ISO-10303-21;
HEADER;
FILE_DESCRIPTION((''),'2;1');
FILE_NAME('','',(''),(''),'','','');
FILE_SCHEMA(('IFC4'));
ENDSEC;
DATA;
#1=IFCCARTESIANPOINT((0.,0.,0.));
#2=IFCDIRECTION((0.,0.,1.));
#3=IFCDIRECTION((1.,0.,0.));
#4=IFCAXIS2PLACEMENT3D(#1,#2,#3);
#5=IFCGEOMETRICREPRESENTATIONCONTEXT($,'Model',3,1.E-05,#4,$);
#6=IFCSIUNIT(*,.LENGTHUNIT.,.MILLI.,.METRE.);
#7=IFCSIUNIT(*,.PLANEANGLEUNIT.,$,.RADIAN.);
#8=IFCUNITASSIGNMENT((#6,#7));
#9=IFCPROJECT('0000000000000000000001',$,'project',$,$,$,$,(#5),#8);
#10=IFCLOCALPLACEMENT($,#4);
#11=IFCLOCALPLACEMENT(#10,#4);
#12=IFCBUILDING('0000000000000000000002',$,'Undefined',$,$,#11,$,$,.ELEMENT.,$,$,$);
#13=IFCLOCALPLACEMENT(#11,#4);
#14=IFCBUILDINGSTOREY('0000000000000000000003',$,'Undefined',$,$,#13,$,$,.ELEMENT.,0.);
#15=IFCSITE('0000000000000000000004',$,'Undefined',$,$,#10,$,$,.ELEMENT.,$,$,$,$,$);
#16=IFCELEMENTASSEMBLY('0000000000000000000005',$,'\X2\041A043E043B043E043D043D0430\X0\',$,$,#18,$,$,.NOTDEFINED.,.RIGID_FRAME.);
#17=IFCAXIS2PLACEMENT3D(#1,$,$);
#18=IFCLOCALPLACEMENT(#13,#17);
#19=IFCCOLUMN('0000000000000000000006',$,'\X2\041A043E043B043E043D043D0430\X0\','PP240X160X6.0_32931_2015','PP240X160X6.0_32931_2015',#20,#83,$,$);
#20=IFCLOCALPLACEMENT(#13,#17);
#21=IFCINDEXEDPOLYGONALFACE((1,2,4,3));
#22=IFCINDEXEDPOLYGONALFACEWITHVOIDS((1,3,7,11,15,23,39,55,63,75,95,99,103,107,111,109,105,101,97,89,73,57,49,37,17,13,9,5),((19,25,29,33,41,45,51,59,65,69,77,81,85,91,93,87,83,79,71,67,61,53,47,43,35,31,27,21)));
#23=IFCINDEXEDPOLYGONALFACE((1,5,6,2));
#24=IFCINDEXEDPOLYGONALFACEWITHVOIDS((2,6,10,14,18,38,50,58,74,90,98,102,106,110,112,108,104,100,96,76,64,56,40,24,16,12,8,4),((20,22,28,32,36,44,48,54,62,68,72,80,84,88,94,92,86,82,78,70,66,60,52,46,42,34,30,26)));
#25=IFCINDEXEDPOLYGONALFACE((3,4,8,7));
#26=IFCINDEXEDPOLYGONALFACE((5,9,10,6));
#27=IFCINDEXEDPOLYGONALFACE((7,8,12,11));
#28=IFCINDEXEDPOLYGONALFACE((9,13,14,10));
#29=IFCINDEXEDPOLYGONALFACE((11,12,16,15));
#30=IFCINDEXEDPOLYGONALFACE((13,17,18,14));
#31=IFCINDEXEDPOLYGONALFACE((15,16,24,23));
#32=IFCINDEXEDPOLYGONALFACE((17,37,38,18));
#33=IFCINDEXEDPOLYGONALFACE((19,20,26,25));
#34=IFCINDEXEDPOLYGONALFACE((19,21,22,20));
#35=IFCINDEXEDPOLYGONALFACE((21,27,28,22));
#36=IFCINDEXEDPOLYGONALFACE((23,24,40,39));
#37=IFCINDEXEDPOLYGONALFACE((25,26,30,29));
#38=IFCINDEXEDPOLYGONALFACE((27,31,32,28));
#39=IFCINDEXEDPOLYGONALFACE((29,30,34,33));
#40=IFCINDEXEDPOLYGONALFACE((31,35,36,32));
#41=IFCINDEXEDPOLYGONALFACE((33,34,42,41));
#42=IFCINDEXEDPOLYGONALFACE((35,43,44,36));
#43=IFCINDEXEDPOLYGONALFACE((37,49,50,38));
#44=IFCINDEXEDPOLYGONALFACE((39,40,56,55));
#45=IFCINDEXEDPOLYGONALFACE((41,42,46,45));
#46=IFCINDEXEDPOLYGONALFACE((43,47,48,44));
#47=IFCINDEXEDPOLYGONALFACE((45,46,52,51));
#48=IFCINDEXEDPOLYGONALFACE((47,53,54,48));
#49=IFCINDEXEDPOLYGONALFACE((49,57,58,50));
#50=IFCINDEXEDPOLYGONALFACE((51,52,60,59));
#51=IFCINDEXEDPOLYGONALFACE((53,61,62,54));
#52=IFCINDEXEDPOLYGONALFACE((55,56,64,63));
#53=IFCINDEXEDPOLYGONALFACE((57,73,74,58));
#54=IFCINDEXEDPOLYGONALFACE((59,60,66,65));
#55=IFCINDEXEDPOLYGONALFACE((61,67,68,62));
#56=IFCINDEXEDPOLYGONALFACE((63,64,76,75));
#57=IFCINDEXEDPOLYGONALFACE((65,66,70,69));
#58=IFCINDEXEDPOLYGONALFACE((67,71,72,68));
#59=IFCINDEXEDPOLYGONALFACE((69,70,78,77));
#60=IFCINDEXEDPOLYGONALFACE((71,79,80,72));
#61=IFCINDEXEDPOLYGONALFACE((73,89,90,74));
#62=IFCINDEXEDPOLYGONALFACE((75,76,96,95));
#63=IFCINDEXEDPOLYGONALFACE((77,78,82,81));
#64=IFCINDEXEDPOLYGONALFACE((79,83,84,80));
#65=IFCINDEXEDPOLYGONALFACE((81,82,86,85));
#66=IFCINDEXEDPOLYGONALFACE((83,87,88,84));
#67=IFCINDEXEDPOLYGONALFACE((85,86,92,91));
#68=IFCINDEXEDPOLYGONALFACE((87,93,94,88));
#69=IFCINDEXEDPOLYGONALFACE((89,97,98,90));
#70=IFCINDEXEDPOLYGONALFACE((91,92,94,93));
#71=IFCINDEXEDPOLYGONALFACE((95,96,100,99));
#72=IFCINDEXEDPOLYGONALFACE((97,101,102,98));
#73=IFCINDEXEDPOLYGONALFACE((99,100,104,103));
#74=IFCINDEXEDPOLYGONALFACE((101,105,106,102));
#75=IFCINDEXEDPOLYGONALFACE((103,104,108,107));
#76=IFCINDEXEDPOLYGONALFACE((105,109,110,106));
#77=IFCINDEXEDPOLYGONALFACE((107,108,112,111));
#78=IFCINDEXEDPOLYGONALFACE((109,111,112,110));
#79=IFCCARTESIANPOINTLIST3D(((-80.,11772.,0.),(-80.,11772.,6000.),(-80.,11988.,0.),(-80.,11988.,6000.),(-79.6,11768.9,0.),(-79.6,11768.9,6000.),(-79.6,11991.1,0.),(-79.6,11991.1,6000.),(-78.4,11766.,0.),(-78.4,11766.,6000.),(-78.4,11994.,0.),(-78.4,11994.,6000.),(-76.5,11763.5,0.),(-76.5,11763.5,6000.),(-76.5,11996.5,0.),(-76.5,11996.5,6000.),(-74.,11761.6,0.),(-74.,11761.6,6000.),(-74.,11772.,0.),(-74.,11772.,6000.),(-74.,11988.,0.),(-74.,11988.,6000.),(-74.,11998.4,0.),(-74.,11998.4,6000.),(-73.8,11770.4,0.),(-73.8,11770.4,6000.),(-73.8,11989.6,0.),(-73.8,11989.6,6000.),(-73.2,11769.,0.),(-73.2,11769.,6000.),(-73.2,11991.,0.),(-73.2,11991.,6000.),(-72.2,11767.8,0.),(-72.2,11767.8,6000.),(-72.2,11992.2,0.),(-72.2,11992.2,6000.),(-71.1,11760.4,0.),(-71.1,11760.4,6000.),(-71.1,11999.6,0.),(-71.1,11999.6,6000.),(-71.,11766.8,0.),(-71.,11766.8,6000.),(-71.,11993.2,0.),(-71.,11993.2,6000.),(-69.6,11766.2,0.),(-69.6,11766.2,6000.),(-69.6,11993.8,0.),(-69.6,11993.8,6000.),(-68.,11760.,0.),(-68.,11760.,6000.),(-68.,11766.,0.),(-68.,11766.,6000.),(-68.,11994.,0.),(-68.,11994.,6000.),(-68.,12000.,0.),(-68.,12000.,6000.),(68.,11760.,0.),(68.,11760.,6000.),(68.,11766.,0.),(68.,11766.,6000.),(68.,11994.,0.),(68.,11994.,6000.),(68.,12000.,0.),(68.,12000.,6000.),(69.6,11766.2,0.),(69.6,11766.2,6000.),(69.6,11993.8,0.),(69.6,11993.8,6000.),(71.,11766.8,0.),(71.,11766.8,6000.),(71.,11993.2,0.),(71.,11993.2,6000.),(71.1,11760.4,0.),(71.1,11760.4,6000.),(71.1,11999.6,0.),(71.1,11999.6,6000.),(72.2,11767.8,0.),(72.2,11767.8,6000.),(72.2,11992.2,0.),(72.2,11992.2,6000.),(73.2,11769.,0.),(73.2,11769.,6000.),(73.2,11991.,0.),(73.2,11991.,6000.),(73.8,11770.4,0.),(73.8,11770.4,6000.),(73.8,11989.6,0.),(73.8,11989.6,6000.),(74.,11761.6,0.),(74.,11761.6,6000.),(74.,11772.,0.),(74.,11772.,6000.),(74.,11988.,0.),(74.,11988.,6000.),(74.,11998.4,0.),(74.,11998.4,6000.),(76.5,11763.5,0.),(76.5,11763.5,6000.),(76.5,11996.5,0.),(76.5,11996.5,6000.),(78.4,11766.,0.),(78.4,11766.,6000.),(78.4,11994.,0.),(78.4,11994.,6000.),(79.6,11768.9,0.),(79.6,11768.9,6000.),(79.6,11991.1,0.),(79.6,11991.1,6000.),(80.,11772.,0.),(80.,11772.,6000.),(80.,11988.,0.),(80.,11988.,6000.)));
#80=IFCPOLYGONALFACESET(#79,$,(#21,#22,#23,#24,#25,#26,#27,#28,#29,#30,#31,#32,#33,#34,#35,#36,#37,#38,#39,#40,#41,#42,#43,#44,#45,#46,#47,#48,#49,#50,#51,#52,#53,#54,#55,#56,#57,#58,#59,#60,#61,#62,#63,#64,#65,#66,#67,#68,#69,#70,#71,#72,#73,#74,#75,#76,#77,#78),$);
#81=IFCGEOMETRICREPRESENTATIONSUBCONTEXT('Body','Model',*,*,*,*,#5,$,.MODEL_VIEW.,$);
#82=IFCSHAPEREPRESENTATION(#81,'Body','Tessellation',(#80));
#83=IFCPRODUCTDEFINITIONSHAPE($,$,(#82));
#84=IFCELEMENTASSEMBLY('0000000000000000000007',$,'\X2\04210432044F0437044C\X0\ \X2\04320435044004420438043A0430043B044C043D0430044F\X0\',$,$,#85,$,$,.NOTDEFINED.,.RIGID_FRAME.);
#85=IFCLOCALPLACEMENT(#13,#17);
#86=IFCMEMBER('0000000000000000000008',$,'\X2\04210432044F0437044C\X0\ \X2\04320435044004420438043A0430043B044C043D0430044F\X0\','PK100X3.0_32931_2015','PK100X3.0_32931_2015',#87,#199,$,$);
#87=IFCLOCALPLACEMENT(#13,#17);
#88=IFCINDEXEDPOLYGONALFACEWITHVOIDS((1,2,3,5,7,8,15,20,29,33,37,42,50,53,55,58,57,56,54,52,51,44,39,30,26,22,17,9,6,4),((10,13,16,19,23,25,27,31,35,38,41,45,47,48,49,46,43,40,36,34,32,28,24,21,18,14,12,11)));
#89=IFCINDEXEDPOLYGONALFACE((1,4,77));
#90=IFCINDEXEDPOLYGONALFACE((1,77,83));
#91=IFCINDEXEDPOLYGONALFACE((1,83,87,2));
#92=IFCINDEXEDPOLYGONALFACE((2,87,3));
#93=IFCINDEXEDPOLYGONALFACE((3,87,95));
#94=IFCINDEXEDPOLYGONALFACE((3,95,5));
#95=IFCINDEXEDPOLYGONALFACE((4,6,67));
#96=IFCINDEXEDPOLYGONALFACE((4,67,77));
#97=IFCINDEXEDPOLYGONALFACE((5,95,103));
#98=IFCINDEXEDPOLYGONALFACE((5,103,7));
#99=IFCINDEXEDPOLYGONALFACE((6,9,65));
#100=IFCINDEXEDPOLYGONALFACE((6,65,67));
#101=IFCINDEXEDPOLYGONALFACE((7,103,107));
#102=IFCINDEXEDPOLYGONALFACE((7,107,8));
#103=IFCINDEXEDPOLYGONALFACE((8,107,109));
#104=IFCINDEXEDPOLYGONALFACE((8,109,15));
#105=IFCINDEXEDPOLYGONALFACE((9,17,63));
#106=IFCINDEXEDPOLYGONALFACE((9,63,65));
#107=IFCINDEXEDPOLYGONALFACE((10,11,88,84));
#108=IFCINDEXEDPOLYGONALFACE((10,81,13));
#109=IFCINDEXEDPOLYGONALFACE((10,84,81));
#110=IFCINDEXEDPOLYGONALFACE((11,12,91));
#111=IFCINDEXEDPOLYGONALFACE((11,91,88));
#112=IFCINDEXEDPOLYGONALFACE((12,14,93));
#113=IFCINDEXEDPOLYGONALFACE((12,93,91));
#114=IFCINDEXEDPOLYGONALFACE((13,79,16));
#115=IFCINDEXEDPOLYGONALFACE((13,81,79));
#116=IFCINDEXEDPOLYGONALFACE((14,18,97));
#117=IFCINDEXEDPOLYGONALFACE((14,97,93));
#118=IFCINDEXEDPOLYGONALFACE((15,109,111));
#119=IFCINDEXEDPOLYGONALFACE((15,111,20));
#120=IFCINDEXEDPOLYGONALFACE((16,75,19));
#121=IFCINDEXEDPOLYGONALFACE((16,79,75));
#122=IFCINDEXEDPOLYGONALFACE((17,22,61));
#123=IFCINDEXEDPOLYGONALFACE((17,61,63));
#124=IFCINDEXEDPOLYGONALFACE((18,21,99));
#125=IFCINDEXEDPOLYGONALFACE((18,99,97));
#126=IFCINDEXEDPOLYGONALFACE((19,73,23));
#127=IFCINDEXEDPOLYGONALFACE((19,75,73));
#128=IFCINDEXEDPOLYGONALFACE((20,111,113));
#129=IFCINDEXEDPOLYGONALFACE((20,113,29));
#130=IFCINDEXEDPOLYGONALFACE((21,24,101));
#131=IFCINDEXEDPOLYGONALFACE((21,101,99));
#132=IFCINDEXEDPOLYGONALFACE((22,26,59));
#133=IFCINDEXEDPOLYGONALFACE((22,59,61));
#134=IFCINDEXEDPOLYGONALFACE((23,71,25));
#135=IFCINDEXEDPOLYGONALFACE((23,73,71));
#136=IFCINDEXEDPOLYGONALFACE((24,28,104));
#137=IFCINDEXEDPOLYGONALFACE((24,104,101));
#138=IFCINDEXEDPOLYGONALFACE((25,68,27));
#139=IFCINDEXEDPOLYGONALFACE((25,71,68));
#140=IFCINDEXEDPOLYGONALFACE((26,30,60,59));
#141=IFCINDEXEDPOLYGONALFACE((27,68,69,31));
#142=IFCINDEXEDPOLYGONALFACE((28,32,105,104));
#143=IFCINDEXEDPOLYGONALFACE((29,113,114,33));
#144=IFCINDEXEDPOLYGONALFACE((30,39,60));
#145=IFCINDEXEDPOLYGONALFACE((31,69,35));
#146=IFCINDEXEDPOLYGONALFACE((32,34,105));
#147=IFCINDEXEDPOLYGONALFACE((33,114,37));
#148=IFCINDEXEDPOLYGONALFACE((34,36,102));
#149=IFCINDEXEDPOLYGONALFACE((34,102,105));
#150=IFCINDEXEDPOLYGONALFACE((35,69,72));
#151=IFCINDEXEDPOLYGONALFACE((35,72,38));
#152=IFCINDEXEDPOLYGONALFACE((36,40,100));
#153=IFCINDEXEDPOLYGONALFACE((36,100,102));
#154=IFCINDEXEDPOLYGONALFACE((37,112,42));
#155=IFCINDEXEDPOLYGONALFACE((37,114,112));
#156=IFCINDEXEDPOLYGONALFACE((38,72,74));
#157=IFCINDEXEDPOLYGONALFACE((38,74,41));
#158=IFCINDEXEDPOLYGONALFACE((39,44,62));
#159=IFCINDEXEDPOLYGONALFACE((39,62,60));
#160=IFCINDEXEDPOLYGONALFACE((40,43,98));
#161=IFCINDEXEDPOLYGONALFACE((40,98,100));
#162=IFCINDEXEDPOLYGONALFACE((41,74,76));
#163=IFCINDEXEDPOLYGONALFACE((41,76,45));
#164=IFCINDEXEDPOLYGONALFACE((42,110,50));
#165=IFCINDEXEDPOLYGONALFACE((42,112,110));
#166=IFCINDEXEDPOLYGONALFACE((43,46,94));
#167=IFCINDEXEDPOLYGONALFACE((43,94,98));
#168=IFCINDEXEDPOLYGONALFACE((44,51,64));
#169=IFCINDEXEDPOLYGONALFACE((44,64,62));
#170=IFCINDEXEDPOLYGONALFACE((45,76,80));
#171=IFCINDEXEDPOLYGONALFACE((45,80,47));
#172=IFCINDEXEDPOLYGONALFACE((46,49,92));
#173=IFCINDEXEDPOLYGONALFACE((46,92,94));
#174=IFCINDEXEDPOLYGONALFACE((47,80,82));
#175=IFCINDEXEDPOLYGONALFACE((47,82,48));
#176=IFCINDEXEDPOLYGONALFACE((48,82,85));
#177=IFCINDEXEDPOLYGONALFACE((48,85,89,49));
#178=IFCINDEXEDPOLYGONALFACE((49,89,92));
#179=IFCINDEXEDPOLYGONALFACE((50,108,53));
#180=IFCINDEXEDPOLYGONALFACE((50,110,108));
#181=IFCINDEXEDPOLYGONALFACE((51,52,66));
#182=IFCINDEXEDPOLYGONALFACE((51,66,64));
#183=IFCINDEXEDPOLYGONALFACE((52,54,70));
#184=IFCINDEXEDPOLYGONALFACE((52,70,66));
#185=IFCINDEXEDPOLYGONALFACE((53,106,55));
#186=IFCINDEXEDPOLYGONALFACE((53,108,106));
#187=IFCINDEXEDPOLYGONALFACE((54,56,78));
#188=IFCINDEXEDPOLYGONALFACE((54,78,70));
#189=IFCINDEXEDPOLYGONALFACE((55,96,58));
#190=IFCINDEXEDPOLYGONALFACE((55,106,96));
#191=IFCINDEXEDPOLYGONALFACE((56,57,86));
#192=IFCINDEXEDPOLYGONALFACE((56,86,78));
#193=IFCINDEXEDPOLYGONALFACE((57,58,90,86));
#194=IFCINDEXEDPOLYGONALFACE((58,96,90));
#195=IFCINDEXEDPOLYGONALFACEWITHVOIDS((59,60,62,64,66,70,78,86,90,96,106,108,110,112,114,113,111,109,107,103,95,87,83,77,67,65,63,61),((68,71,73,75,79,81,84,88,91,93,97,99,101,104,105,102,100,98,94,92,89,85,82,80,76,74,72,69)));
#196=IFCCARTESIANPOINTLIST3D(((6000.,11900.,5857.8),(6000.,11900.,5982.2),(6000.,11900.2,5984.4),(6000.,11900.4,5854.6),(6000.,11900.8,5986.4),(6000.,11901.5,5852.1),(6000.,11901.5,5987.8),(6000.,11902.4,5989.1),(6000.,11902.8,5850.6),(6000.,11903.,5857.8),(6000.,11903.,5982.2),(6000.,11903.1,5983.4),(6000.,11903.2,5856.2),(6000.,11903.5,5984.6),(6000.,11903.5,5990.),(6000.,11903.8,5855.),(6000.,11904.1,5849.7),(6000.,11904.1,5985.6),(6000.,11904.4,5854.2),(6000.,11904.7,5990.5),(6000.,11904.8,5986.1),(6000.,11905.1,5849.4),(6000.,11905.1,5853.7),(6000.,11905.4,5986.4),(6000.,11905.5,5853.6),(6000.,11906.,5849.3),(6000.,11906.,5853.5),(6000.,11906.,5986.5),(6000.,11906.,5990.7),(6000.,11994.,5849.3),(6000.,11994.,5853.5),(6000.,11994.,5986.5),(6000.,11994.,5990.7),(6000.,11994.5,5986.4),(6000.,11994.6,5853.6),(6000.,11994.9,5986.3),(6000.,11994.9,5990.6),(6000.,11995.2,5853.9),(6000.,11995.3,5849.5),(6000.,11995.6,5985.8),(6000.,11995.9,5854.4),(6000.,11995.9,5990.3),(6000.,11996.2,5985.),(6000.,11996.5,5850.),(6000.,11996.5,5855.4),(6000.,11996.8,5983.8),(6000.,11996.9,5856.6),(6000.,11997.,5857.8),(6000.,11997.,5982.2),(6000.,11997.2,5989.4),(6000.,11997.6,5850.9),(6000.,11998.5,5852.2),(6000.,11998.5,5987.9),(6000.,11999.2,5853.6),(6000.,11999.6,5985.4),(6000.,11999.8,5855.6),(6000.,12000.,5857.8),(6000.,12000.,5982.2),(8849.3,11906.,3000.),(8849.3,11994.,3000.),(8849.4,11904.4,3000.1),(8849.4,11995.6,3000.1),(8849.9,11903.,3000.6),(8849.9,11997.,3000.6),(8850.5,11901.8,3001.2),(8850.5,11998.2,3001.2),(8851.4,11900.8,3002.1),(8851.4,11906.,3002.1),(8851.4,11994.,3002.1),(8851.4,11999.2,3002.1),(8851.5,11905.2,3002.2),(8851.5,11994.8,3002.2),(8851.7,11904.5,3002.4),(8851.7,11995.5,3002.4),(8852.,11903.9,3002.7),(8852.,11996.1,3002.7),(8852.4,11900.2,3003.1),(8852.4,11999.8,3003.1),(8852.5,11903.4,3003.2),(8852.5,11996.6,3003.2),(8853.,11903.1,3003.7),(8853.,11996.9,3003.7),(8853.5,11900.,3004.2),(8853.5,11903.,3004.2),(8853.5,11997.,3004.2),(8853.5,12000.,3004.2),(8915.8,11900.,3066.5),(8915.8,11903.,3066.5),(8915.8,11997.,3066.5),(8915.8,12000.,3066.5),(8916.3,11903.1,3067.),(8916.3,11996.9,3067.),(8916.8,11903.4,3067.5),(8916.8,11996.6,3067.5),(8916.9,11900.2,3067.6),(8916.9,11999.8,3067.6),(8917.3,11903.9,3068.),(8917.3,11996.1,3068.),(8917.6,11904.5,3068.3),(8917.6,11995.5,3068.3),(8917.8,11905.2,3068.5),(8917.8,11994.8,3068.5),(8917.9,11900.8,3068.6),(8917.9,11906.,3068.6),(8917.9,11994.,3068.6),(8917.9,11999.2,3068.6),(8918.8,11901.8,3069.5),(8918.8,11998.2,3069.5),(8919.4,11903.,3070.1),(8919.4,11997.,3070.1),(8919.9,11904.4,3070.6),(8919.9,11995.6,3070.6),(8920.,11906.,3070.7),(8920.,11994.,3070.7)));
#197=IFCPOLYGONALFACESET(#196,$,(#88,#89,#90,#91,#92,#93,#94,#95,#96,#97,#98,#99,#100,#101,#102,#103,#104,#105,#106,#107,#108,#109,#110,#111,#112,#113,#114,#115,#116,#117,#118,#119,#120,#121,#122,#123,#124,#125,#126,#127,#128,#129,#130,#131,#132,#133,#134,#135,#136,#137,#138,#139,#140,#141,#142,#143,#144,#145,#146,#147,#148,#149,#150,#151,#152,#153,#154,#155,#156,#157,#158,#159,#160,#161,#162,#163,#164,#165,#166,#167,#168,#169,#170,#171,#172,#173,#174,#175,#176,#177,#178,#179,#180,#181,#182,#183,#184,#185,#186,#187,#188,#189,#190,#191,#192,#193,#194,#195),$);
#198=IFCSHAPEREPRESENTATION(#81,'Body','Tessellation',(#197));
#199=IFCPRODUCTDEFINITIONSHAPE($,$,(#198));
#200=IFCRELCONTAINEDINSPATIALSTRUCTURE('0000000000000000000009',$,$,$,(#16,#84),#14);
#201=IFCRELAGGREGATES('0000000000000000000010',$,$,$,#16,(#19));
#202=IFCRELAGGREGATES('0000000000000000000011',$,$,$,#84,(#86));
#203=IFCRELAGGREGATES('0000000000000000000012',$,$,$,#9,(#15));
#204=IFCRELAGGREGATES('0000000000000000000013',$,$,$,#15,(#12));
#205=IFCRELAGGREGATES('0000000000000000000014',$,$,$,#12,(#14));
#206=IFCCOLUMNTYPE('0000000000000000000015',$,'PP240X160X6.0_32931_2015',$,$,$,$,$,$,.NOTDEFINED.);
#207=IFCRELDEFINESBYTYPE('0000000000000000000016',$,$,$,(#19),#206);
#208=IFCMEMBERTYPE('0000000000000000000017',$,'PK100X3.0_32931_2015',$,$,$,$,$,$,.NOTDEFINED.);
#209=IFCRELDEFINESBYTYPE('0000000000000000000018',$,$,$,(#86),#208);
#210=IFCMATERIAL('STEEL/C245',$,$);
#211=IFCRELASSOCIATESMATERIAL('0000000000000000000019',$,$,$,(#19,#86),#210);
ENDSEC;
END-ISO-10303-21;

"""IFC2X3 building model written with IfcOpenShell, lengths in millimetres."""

from ifc_helpers import new_model, si_unit, frame, origin_with_axes, origin_2d_with_axis, place, context, subcontext, project, spatial, hollow_rectangle, extrude, clip, halfspace, material, type_object, element, aggregate, save


model = new_model("IFC2X3")

# Units and contexts
model_context = context("Model", 3, precision=1e-05, world=origin_with_axes())
body_context = subcontext(model_context, "Body", "Model", "MODEL_VIEW")
ifc_project = project(units=[si_unit("LENGTHUNIT", "METRE", prefix="MILLI"), si_unit("PLANEANGLEUNIT", "RADIAN")], contexts=[model_context])

# Site, building, storey
site_placement = place(None, origin_with_axes())
site = spatial("IfcSite", under=ifc_project, at=site_placement, Name="Undefined", CompositionType="ELEMENT")
building_placement = place(site_placement, origin_with_axes())
building = spatial("IfcBuilding", under=site, at=building_placement, Name="Undefined", CompositionType="ELEMENT")
storey_placement = place(building_placement, origin_with_axes())
storey = spatial("IfcBuildingStorey", under=building, at=storey_placement, Name="Undefined", CompositionType="ELEMENT", Elevation=0.0)

# Element assembly, column
ifc_material = material(Name="STEEL/C245")
column_type_1 = type_object("IfcColumnType", Name="PP240X160X6.0_32931_2015", PredefinedType="NOTDEFINED")
assembly_1_placement = place(storey_placement, origin_with_axes())
assembly_1 = element("IfcElementAssembly", 1, at=assembly_1_placement, inside=storey, Name="Колонна", AssemblyPlace="NOTDEFINED", PredefinedType="RIGID_FRAME")
column_1_placement = place(assembly_1_placement, frame((0.0, 11880.0, 0.0), z_axis=(0.0, 0.0, 1.0), x_axis=(0.0, -1.0, 0.0)))
column_1 = element("IfcColumn", 2, at=column_1_placement, type_object=column_type_1, material=ifc_material, Name="Колонна", Description="PP240X160X6.0_32931_2015", ObjectType="PP240X160X6.0_32931_2015", context=body_context, shape_type="SweptSolid", body=[
    extrude(hollow_rectangle(XDim=160.0, YDim=240.0, WallThickness=6.0, InnerFilletRadius=6.0, OuterFilletRadius=12.0, at=origin_2d_with_axis()), frame((0.0, 0.0, 6000.0), z_axis=(0.0, 0.0, -1.0), x_axis=(0.0, 1.0, 0.0)), (0.0, 0.0, 1.0), 6000.0),
])
aggregate(assembly_1, [column_1])

# Element assembly, member
assembly_2_placement = place(storey_placement, origin_with_axes())
assembly_2 = element("IfcElementAssembly", 3, at=assembly_2_placement, inside=storey, Name="Связь вертикальная", AssemblyPlace="NOTDEFINED", PredefinedType="RIGID_FRAME")
member_type_1 = type_object("IfcMemberType", Name="PK100X3.0_32931_2015", PredefinedType="NOTDEFINED")
member_1_placement = place(assembly_2_placement, frame((8920.0, 11950.0, 3000.0), z_axis=(0.707107, 0.0, 0.707107), x_axis=(-0.707107, 0.0, 0.707107)))
member_1 = element("IfcMember", 4, at=member_1_placement, type_object=member_type_1, material=ifc_material, Name="Связь вертикальная", Description="PK100X3.0_32931_2015", ObjectType="PK100X3.0_32931_2015", context=body_context, shape_type="Clipping", body=[
    clip(clip(extrude(hollow_rectangle(XDim=100.0, YDim=100.0, WallThickness=3.0, InnerFilletRadius=3.0, OuterFilletRadius=6.0, at=origin_2d_with_axis()), frame((4230.5, 0.0, 0.0), z_axis=(-1.0, 0.0, 0.0), x_axis=(0.0, -1.0, 0.0)), (0.0, 0.0, 1.0), 4281.5), halfspace(frame((3995.7, -50.0, -133.8), z_axis=(-0.707107, 0.0, 0.707107), x_axis=(0.0, -1.0, 0.0)), True)), halfspace(frame((50.0, -50.0, -176.9), z_axis=(-1.0, 0.0, 0.0), x_axis=(0.0, 0.0, 1.0)), False)),
])
aggregate(assembly_2, [member_1])

save(model, "model.ifc")
